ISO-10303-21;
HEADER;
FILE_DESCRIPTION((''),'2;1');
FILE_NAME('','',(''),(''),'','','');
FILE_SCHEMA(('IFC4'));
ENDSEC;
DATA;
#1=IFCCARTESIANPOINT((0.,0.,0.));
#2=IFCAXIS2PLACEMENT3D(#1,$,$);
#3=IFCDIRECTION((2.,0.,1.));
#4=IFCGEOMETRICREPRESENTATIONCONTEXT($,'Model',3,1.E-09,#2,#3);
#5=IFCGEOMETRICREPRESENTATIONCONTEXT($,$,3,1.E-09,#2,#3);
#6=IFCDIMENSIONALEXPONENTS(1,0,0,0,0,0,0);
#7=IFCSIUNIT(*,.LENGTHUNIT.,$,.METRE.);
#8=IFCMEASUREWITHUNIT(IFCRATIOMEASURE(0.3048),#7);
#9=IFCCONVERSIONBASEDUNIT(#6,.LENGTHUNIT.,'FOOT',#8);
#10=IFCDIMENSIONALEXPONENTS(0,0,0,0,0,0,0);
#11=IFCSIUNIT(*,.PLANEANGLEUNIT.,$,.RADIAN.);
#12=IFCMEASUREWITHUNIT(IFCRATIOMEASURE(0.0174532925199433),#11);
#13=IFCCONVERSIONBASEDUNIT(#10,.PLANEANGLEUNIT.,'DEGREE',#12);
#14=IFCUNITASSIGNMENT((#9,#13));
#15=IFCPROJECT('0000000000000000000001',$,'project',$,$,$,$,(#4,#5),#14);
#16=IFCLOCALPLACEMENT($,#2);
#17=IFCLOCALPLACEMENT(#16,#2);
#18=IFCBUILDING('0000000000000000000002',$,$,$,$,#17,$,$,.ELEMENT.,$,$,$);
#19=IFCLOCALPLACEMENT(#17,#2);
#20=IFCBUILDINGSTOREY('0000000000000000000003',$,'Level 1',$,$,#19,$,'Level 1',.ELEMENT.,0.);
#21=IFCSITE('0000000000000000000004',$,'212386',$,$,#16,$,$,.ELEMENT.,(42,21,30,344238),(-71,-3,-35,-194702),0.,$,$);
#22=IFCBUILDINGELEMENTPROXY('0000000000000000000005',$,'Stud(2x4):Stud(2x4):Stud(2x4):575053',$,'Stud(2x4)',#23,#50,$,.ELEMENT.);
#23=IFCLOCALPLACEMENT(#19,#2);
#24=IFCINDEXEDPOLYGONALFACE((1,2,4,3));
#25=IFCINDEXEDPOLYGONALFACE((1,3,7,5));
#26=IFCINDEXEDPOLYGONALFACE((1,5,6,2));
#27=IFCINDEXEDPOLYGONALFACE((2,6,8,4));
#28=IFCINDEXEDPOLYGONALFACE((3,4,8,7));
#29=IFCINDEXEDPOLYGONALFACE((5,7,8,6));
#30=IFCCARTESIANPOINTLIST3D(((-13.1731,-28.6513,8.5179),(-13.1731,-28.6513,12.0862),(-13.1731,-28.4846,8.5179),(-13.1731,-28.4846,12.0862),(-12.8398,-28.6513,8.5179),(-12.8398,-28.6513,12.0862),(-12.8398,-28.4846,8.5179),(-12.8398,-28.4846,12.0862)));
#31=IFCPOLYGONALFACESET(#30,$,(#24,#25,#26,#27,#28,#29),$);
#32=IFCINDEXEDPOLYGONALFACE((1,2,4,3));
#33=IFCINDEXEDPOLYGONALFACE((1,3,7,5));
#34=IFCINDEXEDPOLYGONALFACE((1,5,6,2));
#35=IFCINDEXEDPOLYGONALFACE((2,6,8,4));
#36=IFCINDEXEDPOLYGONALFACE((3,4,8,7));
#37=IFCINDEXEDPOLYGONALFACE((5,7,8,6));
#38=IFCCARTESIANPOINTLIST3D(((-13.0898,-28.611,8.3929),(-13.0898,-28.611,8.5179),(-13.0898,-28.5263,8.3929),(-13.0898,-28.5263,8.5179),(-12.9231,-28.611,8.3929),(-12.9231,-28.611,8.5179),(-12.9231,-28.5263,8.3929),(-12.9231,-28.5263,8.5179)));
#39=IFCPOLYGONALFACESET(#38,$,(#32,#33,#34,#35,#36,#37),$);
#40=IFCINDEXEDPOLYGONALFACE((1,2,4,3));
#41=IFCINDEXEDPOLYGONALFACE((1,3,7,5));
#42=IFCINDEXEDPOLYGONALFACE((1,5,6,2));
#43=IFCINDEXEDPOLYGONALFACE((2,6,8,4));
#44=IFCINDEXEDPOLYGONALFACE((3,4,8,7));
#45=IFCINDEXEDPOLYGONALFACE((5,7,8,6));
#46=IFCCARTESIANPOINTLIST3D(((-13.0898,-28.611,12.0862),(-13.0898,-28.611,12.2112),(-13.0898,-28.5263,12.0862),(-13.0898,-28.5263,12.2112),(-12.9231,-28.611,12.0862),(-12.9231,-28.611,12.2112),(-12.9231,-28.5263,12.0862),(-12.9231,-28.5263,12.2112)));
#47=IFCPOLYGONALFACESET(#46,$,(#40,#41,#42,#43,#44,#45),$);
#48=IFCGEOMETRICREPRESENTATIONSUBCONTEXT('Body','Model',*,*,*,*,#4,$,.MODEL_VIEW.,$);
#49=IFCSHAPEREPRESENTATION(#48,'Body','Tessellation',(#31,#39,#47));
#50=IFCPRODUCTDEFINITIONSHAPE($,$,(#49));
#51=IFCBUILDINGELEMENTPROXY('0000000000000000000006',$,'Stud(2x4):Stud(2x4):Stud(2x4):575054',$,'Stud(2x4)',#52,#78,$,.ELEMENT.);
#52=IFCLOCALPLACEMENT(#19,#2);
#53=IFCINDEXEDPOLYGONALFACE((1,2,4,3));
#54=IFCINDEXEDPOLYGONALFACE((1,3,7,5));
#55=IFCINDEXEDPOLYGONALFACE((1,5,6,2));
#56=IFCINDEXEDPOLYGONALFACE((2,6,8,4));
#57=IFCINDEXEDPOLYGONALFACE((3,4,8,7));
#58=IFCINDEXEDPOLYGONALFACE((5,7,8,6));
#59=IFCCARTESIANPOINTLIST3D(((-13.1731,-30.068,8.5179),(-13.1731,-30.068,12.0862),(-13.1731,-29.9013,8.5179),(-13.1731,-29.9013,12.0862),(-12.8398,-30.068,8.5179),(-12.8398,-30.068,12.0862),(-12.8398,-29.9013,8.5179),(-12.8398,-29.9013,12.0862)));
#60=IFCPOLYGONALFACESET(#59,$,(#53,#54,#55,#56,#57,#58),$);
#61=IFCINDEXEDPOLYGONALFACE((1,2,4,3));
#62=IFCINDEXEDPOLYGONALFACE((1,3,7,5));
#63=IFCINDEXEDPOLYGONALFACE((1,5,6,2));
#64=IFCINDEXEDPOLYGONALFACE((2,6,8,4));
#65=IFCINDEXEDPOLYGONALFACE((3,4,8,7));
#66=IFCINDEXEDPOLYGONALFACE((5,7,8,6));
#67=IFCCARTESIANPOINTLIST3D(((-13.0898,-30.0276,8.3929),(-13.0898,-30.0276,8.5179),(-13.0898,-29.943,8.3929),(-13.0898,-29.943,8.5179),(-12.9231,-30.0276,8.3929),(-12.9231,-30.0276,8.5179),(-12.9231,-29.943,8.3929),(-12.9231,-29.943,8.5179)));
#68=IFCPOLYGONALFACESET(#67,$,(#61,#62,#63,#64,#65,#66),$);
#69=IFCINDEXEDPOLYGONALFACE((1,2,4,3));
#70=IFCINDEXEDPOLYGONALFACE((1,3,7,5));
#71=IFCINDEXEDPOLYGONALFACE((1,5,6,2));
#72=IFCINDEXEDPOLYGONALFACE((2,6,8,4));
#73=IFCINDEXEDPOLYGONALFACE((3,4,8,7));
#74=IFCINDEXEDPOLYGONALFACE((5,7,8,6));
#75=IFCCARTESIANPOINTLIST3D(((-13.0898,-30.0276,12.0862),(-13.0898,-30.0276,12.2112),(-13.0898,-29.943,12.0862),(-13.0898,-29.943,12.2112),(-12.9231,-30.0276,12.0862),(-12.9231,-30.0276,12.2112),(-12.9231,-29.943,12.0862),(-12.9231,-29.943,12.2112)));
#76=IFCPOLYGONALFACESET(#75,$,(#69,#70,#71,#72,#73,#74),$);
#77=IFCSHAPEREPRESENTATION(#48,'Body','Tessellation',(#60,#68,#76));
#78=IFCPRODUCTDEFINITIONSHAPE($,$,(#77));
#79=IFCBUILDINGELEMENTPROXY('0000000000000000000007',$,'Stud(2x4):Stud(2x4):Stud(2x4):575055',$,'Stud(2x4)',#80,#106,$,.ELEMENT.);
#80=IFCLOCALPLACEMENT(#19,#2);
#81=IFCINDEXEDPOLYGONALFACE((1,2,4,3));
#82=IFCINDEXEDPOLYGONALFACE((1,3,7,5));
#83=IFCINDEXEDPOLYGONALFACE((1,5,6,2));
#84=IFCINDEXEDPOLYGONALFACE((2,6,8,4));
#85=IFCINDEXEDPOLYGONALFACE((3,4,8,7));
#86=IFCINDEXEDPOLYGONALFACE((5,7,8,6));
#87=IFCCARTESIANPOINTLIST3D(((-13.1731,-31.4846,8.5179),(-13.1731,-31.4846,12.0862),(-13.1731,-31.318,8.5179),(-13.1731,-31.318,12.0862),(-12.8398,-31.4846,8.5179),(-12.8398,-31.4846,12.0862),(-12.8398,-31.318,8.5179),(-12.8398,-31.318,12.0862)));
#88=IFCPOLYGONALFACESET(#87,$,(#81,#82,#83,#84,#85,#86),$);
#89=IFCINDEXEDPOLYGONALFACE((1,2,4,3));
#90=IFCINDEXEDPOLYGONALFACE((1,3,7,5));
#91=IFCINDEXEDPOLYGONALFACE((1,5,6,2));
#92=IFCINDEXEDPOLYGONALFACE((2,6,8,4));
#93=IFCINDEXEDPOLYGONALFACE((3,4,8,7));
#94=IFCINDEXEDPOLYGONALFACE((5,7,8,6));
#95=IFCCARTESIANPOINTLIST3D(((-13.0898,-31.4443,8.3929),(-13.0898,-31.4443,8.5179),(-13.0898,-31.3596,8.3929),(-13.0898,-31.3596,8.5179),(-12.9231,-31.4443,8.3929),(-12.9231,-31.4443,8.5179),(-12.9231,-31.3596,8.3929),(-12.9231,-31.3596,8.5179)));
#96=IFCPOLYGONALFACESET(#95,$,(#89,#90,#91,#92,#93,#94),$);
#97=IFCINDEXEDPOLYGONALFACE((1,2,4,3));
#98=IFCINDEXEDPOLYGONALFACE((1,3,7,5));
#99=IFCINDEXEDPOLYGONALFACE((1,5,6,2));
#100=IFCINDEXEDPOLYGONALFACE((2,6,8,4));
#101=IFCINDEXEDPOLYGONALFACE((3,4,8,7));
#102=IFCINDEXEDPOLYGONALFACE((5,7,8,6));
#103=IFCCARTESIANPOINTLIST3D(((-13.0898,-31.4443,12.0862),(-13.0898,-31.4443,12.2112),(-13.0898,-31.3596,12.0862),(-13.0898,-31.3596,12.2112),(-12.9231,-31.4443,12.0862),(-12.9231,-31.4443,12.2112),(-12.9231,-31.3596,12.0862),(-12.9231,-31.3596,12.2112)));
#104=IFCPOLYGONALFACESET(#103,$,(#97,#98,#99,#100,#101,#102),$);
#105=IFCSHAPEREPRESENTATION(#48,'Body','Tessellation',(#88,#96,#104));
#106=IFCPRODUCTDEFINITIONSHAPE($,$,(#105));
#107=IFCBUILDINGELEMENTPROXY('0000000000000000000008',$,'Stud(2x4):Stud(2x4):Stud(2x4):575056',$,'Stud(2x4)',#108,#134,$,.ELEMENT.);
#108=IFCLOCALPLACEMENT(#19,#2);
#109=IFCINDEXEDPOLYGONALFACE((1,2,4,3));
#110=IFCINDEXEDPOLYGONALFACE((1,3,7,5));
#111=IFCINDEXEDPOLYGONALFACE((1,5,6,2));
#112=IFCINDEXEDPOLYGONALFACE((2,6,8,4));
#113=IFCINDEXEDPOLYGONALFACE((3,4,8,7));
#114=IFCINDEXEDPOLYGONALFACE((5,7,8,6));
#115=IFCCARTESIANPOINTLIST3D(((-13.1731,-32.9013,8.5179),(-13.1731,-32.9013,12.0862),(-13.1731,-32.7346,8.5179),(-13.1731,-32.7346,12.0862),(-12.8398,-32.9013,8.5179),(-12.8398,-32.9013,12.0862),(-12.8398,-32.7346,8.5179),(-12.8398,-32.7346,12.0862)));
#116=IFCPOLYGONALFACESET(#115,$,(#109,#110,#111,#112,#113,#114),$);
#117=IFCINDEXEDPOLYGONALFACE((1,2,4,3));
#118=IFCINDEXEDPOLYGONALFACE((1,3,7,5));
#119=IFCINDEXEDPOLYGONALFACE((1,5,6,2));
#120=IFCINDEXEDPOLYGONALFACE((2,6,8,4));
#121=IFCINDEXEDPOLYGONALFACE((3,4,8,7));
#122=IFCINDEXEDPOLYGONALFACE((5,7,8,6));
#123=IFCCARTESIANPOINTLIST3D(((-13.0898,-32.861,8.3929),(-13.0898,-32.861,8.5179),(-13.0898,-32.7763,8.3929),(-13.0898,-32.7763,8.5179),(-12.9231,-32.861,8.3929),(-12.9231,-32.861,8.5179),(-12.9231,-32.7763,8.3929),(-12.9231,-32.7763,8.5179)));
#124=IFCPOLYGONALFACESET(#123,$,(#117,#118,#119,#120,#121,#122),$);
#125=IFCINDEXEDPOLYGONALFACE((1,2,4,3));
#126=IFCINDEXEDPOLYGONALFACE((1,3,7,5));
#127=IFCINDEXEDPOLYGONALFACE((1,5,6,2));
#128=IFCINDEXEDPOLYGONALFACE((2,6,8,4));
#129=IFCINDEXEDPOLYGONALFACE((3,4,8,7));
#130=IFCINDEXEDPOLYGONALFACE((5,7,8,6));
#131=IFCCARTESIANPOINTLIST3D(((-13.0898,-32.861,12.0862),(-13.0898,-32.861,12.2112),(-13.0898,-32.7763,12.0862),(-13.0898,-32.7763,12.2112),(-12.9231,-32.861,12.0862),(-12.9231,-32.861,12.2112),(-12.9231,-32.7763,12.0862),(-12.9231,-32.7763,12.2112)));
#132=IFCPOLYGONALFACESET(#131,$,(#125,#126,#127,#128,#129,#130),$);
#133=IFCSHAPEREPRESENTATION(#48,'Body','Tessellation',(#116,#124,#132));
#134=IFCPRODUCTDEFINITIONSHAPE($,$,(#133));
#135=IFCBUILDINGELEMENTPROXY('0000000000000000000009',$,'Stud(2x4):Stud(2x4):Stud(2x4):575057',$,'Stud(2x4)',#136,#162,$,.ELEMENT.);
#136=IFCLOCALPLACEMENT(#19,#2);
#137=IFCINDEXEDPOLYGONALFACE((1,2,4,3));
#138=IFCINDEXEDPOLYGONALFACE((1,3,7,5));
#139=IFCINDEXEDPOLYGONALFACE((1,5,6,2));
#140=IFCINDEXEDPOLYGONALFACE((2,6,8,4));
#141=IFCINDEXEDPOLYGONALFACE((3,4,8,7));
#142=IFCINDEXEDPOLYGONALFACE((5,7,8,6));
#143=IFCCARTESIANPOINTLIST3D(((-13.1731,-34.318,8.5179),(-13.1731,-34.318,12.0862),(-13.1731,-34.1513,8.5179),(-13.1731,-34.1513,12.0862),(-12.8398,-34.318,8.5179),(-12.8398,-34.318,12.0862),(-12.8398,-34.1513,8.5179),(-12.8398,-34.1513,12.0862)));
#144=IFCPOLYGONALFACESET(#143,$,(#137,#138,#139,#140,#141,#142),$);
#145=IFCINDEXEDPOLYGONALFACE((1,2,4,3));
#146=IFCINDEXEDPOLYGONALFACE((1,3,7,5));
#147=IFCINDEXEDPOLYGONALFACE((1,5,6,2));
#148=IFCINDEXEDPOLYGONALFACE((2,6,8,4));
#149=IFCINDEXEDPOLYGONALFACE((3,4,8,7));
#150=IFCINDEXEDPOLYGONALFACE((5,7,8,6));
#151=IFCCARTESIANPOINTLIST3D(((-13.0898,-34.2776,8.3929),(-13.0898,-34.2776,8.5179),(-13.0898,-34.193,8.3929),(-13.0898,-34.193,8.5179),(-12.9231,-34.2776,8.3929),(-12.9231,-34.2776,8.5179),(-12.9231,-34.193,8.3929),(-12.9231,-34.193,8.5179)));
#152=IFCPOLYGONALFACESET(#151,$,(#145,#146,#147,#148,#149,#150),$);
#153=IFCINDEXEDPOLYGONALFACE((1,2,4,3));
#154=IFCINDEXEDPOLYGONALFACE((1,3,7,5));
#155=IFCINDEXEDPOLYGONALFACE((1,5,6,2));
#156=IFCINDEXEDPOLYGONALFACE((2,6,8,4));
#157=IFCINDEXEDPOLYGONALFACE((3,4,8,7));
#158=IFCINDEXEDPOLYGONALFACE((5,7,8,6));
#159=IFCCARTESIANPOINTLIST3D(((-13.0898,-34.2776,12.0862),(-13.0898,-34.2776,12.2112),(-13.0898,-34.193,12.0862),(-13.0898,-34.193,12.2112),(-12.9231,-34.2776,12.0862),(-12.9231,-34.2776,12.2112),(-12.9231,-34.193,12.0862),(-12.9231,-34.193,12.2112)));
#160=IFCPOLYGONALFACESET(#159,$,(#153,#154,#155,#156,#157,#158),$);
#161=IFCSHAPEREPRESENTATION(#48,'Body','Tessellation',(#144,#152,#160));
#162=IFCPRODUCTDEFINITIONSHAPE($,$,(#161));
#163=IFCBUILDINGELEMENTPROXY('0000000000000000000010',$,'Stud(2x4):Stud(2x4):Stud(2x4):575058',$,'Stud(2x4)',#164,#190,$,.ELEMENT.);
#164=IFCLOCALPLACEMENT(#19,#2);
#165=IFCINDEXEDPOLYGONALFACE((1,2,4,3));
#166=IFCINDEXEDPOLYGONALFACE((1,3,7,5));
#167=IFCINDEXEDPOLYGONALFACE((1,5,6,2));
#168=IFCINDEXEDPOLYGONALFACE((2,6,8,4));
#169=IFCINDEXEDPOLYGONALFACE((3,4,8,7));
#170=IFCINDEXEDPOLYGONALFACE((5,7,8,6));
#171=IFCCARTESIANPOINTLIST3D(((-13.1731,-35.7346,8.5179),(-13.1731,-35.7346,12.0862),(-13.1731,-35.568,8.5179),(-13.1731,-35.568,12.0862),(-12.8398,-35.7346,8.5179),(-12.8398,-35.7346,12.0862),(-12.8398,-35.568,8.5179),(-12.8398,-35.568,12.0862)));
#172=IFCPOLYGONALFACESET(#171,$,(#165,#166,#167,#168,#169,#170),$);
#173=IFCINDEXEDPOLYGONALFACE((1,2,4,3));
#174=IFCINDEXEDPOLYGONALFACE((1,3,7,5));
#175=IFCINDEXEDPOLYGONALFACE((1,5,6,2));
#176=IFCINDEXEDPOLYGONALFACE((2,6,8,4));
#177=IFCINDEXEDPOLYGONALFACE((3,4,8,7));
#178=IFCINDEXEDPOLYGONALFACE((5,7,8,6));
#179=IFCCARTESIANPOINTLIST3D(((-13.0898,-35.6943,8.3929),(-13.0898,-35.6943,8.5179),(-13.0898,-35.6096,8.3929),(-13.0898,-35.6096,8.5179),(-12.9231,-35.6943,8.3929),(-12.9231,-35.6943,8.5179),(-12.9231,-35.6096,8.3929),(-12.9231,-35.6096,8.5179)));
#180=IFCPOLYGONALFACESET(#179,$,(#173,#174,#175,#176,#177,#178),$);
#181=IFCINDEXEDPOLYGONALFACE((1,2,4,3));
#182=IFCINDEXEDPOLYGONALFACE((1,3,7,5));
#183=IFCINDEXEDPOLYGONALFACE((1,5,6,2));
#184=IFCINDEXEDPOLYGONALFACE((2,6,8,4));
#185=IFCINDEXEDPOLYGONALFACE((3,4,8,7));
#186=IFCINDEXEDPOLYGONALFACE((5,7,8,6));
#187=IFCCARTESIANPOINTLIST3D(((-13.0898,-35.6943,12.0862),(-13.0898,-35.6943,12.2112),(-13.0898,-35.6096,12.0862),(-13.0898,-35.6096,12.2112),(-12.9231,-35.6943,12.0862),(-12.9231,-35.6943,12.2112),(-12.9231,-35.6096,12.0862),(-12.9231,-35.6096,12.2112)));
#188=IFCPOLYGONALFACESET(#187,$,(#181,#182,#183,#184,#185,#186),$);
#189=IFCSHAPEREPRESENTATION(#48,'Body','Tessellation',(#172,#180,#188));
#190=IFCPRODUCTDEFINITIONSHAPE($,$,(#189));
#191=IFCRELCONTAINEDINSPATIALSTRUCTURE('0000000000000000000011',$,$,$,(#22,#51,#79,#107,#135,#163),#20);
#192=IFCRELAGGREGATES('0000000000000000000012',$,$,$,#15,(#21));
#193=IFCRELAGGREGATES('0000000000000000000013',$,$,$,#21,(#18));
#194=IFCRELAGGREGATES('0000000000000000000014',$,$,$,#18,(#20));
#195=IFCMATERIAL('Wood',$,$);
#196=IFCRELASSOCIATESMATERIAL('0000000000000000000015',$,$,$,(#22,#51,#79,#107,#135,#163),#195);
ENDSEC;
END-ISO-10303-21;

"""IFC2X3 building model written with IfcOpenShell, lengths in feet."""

from ifc_helpers import new_model, entity, si_unit, converted_unit, direction, frame, frame_2d, origin, place, context, subcontext, project, spatial, rectangle, extrude, source, transform, mapped, material, element, save


model = new_model("IFC2X3")

# Units and contexts
model_context = context("Model", 3, precision=1e-09, world=origin(), true_north=direction((2.0, 0.0, 1.0)))
context_of_model = context(None, 3, precision=1e-09, world=origin(), true_north=direction((2.0, 0.0, 1.0)))
body_context = subcontext(model_context, "Body", "Model", "MODEL_VIEW")
ifc_project = project(units=[converted_unit("LENGTHUNIT", "FOOT", entity("IfcRatioMeasure", 0.3048), si_unit("LENGTHUNIT", "METRE"), dimensions=[1, 0, 0, 0, 0, 0, 0]), converted_unit("PLANEANGLEUNIT", "DEGREE", entity("IfcRatioMeasure", 0.0174532925199433), si_unit("PLANEANGLEUNIT", "RADIAN"), dimensions=[0, 0, 0, 0, 0, 0, 0])], contexts=[model_context, context_of_model])

# Site, building, storey
site_placement = place(None, origin())
site = spatial("IfcSite", under=ifc_project, at=site_placement, Name="212386", CompositionType="ELEMENT", RefLatitude=(42, 21, 30, 344238), RefLongitude=(-71, -3, -35, -194702), RefElevation=0.0)
building_placement = place(site_placement, origin())
building = spatial("IfcBuilding", under=site, at=building_placement, CompositionType="ELEMENT")
storey_placement = place(building_placement, origin())
storey = spatial("IfcBuildingStorey", under=building, at=storey_placement, Name="Level 1", LongName="Level 1", CompositionType="ELEMENT", Elevation=0.0)

# Building element proxies
ifc_material = material(Name="Wood")
shared_shape_1 = source(origin(), body_context, "Body", "SweptSolid", [
    extrude(rectangle(XDim=0.3333, YDim=0.1667, at=frame_2d((0.0, 0.0), x_axis=(1.0, 0.0))), frame((-13.0064, -28.568, 8.5179), z_axis=(0.0, 0.0, 1.0), x_axis=(-1.0, 0.0, 0.0)), (0.0, 0.0, 1.0), 3.5684),
    extrude(rectangle(XDim=0.1667, YDim=0.0847, at=frame_2d((0.0, 0.0), x_axis=(1.0, 0.0))), frame((-13.0064, -28.5686, 8.3929), z_axis=(0.0, 0.0, 1.0), x_axis=(-1.0, 0.0, 0.0)), (0.0, 0.0, 1.0), 0.125),
    extrude(rectangle(XDim=0.0847, YDim=0.1667, at=frame_2d((0.0, 0.0), x_axis=(1.0, 0.0))), frame((-13.0064, -28.5686, 12.0862), z_axis=(0.0, 0.0, 1.0), x_axis=(0.0, -1.0, 0.0)), (0.0, 0.0, 1.0), 0.125),
])
proxy_1_placement = place(storey_placement, origin())
element("IfcBuildingElementProxy", 1, at=proxy_1_placement, inside=storey, material=ifc_material, Name="Stud(2x4):Stud(2x4):Stud(2x4):575053", ObjectType="Stud(2x4)", CompositionType="ELEMENT", context=body_context, shape_type="MappedRepresentation", body=[
    mapped(shared_shape_1, transform((0.0, 0.0, 0.0), scale=1.0)),
])
shared_shape_2 = source(origin(), body_context, "Body", "SweptSolid", [
    extrude(rectangle(XDim=0.3333, YDim=0.1667, at=frame_2d((0.0, 0.0), x_axis=(1.0, 0.0))), frame((-13.0064, -29.9846, 8.5179), z_axis=(0.0, 0.0, 1.0), x_axis=(-1.0, 0.0, 0.0)), (0.0, 0.0, 1.0), 3.5684),
    extrude(rectangle(XDim=0.1667, YDim=0.0847, at=frame_2d((0.0, 0.0), x_axis=(1.0, 0.0))), frame((-13.0064, -29.9853, 8.3929), z_axis=(0.0, 0.0, 1.0), x_axis=(-1.0, 0.0, 0.0)), (0.0, 0.0, 1.0), 0.125),
    extrude(rectangle(XDim=0.0847, YDim=0.1667, at=frame_2d((0.0, 0.0), x_axis=(1.0, 0.0))), frame((-13.0064, -29.9853, 12.0862), z_axis=(0.0, 0.0, 1.0), x_axis=(0.0, -1.0, 0.0)), (0.0, 0.0, 1.0), 0.125),
])
proxy_2_placement = place(storey_placement, origin())
element("IfcBuildingElementProxy", 2, at=proxy_2_placement, inside=storey, material=ifc_material, Name="Stud(2x4):Stud(2x4):Stud(2x4):575054", ObjectType="Stud(2x4)", CompositionType="ELEMENT", context=body_context, shape_type="MappedRepresentation", body=[
    mapped(shared_shape_2, transform((0.0, 0.0, 0.0), scale=1.0)),
])
shared_shape_3 = source(origin(), body_context, "Body", "SweptSolid", [
    extrude(rectangle(XDim=0.3333, YDim=0.1667, at=frame_2d((0.0, 0.0), x_axis=(1.0, 0.0))), frame((-13.0064, -31.4013, 8.5179), z_axis=(0.0, 0.0, 1.0), x_axis=(-1.0, 0.0, 0.0)), (0.0, 0.0, 1.0), 3.5684),
    extrude(rectangle(XDim=0.1667, YDim=0.0847, at=frame_2d((0.0, 0.0), x_axis=(1.0, 0.0))), frame((-13.0064, -31.402, 8.3929), z_axis=(0.0, 0.0, 1.0), x_axis=(-1.0, 0.0, 0.0)), (0.0, 0.0, 1.0), 0.125),
    extrude(rectangle(XDim=0.0847, YDim=0.1667, at=frame_2d((0.0, 0.0), x_axis=(1.0, 0.0))), frame((-13.0064, -31.402, 12.0862), z_axis=(0.0, 0.0, 1.0), x_axis=(0.0, -1.0, 0.0)), (0.0, 0.0, 1.0), 0.125),
])
proxy_3_placement = place(storey_placement, origin())
element("IfcBuildingElementProxy", 3, at=proxy_3_placement, inside=storey, material=ifc_material, Name="Stud(2x4):Stud(2x4):Stud(2x4):575055", ObjectType="Stud(2x4)", CompositionType="ELEMENT", context=body_context, shape_type="MappedRepresentation", body=[
    mapped(shared_shape_3, transform((0.0, 0.0, 0.0), scale=1.0)),
])
shared_shape_4 = source(origin(), body_context, "Body", "SweptSolid", [
    extrude(rectangle(XDim=0.3333, YDim=0.1667, at=frame_2d((0.0, 0.0), x_axis=(1.0, 0.0))), frame((-13.0064, -32.818, 8.5179), z_axis=(0.0, 0.0, 1.0), x_axis=(-1.0, 0.0, 0.0)), (0.0, 0.0, 1.0), 3.5684),
    extrude(rectangle(XDim=0.1667, YDim=0.0847, at=frame_2d((0.0, 0.0), x_axis=(1.0, 0.0))), frame((-13.0064, -32.8186, 8.3929), z_axis=(0.0, 0.0, 1.0), x_axis=(-1.0, 0.0, 0.0)), (0.0, 0.0, 1.0), 0.125),
    extrude(rectangle(XDim=0.0847, YDim=0.1667, at=frame_2d((0.0, 0.0), x_axis=(1.0, 0.0))), frame((-13.0064, -32.8186, 12.0862), z_axis=(0.0, 0.0, 1.0), x_axis=(0.0, -1.0, 0.0)), (0.0, 0.0, 1.0), 0.125),
])
proxy_4_placement = place(storey_placement, origin())
element("IfcBuildingElementProxy", 4, at=proxy_4_placement, inside=storey, material=ifc_material, Name="Stud(2x4):Stud(2x4):Stud(2x4):575056", ObjectType="Stud(2x4)", CompositionType="ELEMENT", context=body_context, shape_type="MappedRepresentation", body=[
    mapped(shared_shape_4, transform((0.0, 0.0, 0.0), scale=1.0)),
])
shared_shape_5 = source(origin(), body_context, "Body", "SweptSolid", [
    extrude(rectangle(XDim=0.3333, YDim=0.1667, at=frame_2d((0.0, 0.0), x_axis=(1.0, 0.0))), frame((-13.0064, -34.2346, 8.5179), z_axis=(0.0, 0.0, 1.0), x_axis=(-1.0, 0.0, 0.0)), (0.0, 0.0, 1.0), 3.5684),
    extrude(rectangle(XDim=0.1667, YDim=0.0847, at=frame_2d((0.0, 0.0), x_axis=(1.0, 0.0))), frame((-13.0064, -34.2353, 8.3929), z_axis=(0.0, 0.0, 1.0), x_axis=(-1.0, 0.0, 0.0)), (0.0, 0.0, 1.0), 0.125),
    extrude(rectangle(XDim=0.0847, YDim=0.1667, at=frame_2d((0.0, 0.0), x_axis=(1.0, 0.0))), frame((-13.0064, -34.2353, 12.0862), z_axis=(0.0, 0.0, 1.0), x_axis=(0.0, -1.0, 0.0)), (0.0, 0.0, 1.0), 0.125),
])
proxy_5_placement = place(storey_placement, origin())
element("IfcBuildingElementProxy", 5, at=proxy_5_placement, inside=storey, material=ifc_material, Name="Stud(2x4):Stud(2x4):Stud(2x4):575057", ObjectType="Stud(2x4)", CompositionType="ELEMENT", context=body_context, shape_type="MappedRepresentation", body=[
    mapped(shared_shape_5, transform((0.0, 0.0, 0.0), scale=1.0)),
])
shared_shape_6 = source(origin(), body_context, "Body", "SweptSolid", [
    extrude(rectangle(XDim=0.3333, YDim=0.1667, at=frame_2d((0.0, 0.0), x_axis=(1.0, 0.0))), frame((-13.0064, -35.6513, 8.5179), z_axis=(0.0, 0.0, 1.0), x_axis=(-1.0, 0.0, 0.0)), (0.0, 0.0, 1.0), 3.5684),
    extrude(rectangle(XDim=0.1667, YDim=0.0847, at=frame_2d((0.0, 0.0), x_axis=(1.0, 0.0))), frame((-13.0064, -35.652, 8.3929), z_axis=(0.0, 0.0, 1.0), x_axis=(-1.0, 0.0, 0.0)), (0.0, 0.0, 1.0), 0.125),
    extrude(rectangle(XDim=0.0847, YDim=0.1667, at=frame_2d((0.0, 0.0), x_axis=(1.0, 0.0))), frame((-13.0064, -35.652, 12.0862), z_axis=(0.0, 0.0, 1.0), x_axis=(0.0, -1.0, 0.0)), (0.0, 0.0, 1.0), 0.125),
])
proxy_6_placement = place(storey_placement, origin())
element("IfcBuildingElementProxy", 6, at=proxy_6_placement, inside=storey, material=ifc_material, Name="Stud(2x4):Stud(2x4):Stud(2x4):575058", ObjectType="Stud(2x4)", CompositionType="ELEMENT", context=body_context, shape_type="MappedRepresentation", body=[
    mapped(shared_shape_6, transform((0.0, 0.0, 0.0), scale=1.0)),
])

save(model, "model.ifc")
